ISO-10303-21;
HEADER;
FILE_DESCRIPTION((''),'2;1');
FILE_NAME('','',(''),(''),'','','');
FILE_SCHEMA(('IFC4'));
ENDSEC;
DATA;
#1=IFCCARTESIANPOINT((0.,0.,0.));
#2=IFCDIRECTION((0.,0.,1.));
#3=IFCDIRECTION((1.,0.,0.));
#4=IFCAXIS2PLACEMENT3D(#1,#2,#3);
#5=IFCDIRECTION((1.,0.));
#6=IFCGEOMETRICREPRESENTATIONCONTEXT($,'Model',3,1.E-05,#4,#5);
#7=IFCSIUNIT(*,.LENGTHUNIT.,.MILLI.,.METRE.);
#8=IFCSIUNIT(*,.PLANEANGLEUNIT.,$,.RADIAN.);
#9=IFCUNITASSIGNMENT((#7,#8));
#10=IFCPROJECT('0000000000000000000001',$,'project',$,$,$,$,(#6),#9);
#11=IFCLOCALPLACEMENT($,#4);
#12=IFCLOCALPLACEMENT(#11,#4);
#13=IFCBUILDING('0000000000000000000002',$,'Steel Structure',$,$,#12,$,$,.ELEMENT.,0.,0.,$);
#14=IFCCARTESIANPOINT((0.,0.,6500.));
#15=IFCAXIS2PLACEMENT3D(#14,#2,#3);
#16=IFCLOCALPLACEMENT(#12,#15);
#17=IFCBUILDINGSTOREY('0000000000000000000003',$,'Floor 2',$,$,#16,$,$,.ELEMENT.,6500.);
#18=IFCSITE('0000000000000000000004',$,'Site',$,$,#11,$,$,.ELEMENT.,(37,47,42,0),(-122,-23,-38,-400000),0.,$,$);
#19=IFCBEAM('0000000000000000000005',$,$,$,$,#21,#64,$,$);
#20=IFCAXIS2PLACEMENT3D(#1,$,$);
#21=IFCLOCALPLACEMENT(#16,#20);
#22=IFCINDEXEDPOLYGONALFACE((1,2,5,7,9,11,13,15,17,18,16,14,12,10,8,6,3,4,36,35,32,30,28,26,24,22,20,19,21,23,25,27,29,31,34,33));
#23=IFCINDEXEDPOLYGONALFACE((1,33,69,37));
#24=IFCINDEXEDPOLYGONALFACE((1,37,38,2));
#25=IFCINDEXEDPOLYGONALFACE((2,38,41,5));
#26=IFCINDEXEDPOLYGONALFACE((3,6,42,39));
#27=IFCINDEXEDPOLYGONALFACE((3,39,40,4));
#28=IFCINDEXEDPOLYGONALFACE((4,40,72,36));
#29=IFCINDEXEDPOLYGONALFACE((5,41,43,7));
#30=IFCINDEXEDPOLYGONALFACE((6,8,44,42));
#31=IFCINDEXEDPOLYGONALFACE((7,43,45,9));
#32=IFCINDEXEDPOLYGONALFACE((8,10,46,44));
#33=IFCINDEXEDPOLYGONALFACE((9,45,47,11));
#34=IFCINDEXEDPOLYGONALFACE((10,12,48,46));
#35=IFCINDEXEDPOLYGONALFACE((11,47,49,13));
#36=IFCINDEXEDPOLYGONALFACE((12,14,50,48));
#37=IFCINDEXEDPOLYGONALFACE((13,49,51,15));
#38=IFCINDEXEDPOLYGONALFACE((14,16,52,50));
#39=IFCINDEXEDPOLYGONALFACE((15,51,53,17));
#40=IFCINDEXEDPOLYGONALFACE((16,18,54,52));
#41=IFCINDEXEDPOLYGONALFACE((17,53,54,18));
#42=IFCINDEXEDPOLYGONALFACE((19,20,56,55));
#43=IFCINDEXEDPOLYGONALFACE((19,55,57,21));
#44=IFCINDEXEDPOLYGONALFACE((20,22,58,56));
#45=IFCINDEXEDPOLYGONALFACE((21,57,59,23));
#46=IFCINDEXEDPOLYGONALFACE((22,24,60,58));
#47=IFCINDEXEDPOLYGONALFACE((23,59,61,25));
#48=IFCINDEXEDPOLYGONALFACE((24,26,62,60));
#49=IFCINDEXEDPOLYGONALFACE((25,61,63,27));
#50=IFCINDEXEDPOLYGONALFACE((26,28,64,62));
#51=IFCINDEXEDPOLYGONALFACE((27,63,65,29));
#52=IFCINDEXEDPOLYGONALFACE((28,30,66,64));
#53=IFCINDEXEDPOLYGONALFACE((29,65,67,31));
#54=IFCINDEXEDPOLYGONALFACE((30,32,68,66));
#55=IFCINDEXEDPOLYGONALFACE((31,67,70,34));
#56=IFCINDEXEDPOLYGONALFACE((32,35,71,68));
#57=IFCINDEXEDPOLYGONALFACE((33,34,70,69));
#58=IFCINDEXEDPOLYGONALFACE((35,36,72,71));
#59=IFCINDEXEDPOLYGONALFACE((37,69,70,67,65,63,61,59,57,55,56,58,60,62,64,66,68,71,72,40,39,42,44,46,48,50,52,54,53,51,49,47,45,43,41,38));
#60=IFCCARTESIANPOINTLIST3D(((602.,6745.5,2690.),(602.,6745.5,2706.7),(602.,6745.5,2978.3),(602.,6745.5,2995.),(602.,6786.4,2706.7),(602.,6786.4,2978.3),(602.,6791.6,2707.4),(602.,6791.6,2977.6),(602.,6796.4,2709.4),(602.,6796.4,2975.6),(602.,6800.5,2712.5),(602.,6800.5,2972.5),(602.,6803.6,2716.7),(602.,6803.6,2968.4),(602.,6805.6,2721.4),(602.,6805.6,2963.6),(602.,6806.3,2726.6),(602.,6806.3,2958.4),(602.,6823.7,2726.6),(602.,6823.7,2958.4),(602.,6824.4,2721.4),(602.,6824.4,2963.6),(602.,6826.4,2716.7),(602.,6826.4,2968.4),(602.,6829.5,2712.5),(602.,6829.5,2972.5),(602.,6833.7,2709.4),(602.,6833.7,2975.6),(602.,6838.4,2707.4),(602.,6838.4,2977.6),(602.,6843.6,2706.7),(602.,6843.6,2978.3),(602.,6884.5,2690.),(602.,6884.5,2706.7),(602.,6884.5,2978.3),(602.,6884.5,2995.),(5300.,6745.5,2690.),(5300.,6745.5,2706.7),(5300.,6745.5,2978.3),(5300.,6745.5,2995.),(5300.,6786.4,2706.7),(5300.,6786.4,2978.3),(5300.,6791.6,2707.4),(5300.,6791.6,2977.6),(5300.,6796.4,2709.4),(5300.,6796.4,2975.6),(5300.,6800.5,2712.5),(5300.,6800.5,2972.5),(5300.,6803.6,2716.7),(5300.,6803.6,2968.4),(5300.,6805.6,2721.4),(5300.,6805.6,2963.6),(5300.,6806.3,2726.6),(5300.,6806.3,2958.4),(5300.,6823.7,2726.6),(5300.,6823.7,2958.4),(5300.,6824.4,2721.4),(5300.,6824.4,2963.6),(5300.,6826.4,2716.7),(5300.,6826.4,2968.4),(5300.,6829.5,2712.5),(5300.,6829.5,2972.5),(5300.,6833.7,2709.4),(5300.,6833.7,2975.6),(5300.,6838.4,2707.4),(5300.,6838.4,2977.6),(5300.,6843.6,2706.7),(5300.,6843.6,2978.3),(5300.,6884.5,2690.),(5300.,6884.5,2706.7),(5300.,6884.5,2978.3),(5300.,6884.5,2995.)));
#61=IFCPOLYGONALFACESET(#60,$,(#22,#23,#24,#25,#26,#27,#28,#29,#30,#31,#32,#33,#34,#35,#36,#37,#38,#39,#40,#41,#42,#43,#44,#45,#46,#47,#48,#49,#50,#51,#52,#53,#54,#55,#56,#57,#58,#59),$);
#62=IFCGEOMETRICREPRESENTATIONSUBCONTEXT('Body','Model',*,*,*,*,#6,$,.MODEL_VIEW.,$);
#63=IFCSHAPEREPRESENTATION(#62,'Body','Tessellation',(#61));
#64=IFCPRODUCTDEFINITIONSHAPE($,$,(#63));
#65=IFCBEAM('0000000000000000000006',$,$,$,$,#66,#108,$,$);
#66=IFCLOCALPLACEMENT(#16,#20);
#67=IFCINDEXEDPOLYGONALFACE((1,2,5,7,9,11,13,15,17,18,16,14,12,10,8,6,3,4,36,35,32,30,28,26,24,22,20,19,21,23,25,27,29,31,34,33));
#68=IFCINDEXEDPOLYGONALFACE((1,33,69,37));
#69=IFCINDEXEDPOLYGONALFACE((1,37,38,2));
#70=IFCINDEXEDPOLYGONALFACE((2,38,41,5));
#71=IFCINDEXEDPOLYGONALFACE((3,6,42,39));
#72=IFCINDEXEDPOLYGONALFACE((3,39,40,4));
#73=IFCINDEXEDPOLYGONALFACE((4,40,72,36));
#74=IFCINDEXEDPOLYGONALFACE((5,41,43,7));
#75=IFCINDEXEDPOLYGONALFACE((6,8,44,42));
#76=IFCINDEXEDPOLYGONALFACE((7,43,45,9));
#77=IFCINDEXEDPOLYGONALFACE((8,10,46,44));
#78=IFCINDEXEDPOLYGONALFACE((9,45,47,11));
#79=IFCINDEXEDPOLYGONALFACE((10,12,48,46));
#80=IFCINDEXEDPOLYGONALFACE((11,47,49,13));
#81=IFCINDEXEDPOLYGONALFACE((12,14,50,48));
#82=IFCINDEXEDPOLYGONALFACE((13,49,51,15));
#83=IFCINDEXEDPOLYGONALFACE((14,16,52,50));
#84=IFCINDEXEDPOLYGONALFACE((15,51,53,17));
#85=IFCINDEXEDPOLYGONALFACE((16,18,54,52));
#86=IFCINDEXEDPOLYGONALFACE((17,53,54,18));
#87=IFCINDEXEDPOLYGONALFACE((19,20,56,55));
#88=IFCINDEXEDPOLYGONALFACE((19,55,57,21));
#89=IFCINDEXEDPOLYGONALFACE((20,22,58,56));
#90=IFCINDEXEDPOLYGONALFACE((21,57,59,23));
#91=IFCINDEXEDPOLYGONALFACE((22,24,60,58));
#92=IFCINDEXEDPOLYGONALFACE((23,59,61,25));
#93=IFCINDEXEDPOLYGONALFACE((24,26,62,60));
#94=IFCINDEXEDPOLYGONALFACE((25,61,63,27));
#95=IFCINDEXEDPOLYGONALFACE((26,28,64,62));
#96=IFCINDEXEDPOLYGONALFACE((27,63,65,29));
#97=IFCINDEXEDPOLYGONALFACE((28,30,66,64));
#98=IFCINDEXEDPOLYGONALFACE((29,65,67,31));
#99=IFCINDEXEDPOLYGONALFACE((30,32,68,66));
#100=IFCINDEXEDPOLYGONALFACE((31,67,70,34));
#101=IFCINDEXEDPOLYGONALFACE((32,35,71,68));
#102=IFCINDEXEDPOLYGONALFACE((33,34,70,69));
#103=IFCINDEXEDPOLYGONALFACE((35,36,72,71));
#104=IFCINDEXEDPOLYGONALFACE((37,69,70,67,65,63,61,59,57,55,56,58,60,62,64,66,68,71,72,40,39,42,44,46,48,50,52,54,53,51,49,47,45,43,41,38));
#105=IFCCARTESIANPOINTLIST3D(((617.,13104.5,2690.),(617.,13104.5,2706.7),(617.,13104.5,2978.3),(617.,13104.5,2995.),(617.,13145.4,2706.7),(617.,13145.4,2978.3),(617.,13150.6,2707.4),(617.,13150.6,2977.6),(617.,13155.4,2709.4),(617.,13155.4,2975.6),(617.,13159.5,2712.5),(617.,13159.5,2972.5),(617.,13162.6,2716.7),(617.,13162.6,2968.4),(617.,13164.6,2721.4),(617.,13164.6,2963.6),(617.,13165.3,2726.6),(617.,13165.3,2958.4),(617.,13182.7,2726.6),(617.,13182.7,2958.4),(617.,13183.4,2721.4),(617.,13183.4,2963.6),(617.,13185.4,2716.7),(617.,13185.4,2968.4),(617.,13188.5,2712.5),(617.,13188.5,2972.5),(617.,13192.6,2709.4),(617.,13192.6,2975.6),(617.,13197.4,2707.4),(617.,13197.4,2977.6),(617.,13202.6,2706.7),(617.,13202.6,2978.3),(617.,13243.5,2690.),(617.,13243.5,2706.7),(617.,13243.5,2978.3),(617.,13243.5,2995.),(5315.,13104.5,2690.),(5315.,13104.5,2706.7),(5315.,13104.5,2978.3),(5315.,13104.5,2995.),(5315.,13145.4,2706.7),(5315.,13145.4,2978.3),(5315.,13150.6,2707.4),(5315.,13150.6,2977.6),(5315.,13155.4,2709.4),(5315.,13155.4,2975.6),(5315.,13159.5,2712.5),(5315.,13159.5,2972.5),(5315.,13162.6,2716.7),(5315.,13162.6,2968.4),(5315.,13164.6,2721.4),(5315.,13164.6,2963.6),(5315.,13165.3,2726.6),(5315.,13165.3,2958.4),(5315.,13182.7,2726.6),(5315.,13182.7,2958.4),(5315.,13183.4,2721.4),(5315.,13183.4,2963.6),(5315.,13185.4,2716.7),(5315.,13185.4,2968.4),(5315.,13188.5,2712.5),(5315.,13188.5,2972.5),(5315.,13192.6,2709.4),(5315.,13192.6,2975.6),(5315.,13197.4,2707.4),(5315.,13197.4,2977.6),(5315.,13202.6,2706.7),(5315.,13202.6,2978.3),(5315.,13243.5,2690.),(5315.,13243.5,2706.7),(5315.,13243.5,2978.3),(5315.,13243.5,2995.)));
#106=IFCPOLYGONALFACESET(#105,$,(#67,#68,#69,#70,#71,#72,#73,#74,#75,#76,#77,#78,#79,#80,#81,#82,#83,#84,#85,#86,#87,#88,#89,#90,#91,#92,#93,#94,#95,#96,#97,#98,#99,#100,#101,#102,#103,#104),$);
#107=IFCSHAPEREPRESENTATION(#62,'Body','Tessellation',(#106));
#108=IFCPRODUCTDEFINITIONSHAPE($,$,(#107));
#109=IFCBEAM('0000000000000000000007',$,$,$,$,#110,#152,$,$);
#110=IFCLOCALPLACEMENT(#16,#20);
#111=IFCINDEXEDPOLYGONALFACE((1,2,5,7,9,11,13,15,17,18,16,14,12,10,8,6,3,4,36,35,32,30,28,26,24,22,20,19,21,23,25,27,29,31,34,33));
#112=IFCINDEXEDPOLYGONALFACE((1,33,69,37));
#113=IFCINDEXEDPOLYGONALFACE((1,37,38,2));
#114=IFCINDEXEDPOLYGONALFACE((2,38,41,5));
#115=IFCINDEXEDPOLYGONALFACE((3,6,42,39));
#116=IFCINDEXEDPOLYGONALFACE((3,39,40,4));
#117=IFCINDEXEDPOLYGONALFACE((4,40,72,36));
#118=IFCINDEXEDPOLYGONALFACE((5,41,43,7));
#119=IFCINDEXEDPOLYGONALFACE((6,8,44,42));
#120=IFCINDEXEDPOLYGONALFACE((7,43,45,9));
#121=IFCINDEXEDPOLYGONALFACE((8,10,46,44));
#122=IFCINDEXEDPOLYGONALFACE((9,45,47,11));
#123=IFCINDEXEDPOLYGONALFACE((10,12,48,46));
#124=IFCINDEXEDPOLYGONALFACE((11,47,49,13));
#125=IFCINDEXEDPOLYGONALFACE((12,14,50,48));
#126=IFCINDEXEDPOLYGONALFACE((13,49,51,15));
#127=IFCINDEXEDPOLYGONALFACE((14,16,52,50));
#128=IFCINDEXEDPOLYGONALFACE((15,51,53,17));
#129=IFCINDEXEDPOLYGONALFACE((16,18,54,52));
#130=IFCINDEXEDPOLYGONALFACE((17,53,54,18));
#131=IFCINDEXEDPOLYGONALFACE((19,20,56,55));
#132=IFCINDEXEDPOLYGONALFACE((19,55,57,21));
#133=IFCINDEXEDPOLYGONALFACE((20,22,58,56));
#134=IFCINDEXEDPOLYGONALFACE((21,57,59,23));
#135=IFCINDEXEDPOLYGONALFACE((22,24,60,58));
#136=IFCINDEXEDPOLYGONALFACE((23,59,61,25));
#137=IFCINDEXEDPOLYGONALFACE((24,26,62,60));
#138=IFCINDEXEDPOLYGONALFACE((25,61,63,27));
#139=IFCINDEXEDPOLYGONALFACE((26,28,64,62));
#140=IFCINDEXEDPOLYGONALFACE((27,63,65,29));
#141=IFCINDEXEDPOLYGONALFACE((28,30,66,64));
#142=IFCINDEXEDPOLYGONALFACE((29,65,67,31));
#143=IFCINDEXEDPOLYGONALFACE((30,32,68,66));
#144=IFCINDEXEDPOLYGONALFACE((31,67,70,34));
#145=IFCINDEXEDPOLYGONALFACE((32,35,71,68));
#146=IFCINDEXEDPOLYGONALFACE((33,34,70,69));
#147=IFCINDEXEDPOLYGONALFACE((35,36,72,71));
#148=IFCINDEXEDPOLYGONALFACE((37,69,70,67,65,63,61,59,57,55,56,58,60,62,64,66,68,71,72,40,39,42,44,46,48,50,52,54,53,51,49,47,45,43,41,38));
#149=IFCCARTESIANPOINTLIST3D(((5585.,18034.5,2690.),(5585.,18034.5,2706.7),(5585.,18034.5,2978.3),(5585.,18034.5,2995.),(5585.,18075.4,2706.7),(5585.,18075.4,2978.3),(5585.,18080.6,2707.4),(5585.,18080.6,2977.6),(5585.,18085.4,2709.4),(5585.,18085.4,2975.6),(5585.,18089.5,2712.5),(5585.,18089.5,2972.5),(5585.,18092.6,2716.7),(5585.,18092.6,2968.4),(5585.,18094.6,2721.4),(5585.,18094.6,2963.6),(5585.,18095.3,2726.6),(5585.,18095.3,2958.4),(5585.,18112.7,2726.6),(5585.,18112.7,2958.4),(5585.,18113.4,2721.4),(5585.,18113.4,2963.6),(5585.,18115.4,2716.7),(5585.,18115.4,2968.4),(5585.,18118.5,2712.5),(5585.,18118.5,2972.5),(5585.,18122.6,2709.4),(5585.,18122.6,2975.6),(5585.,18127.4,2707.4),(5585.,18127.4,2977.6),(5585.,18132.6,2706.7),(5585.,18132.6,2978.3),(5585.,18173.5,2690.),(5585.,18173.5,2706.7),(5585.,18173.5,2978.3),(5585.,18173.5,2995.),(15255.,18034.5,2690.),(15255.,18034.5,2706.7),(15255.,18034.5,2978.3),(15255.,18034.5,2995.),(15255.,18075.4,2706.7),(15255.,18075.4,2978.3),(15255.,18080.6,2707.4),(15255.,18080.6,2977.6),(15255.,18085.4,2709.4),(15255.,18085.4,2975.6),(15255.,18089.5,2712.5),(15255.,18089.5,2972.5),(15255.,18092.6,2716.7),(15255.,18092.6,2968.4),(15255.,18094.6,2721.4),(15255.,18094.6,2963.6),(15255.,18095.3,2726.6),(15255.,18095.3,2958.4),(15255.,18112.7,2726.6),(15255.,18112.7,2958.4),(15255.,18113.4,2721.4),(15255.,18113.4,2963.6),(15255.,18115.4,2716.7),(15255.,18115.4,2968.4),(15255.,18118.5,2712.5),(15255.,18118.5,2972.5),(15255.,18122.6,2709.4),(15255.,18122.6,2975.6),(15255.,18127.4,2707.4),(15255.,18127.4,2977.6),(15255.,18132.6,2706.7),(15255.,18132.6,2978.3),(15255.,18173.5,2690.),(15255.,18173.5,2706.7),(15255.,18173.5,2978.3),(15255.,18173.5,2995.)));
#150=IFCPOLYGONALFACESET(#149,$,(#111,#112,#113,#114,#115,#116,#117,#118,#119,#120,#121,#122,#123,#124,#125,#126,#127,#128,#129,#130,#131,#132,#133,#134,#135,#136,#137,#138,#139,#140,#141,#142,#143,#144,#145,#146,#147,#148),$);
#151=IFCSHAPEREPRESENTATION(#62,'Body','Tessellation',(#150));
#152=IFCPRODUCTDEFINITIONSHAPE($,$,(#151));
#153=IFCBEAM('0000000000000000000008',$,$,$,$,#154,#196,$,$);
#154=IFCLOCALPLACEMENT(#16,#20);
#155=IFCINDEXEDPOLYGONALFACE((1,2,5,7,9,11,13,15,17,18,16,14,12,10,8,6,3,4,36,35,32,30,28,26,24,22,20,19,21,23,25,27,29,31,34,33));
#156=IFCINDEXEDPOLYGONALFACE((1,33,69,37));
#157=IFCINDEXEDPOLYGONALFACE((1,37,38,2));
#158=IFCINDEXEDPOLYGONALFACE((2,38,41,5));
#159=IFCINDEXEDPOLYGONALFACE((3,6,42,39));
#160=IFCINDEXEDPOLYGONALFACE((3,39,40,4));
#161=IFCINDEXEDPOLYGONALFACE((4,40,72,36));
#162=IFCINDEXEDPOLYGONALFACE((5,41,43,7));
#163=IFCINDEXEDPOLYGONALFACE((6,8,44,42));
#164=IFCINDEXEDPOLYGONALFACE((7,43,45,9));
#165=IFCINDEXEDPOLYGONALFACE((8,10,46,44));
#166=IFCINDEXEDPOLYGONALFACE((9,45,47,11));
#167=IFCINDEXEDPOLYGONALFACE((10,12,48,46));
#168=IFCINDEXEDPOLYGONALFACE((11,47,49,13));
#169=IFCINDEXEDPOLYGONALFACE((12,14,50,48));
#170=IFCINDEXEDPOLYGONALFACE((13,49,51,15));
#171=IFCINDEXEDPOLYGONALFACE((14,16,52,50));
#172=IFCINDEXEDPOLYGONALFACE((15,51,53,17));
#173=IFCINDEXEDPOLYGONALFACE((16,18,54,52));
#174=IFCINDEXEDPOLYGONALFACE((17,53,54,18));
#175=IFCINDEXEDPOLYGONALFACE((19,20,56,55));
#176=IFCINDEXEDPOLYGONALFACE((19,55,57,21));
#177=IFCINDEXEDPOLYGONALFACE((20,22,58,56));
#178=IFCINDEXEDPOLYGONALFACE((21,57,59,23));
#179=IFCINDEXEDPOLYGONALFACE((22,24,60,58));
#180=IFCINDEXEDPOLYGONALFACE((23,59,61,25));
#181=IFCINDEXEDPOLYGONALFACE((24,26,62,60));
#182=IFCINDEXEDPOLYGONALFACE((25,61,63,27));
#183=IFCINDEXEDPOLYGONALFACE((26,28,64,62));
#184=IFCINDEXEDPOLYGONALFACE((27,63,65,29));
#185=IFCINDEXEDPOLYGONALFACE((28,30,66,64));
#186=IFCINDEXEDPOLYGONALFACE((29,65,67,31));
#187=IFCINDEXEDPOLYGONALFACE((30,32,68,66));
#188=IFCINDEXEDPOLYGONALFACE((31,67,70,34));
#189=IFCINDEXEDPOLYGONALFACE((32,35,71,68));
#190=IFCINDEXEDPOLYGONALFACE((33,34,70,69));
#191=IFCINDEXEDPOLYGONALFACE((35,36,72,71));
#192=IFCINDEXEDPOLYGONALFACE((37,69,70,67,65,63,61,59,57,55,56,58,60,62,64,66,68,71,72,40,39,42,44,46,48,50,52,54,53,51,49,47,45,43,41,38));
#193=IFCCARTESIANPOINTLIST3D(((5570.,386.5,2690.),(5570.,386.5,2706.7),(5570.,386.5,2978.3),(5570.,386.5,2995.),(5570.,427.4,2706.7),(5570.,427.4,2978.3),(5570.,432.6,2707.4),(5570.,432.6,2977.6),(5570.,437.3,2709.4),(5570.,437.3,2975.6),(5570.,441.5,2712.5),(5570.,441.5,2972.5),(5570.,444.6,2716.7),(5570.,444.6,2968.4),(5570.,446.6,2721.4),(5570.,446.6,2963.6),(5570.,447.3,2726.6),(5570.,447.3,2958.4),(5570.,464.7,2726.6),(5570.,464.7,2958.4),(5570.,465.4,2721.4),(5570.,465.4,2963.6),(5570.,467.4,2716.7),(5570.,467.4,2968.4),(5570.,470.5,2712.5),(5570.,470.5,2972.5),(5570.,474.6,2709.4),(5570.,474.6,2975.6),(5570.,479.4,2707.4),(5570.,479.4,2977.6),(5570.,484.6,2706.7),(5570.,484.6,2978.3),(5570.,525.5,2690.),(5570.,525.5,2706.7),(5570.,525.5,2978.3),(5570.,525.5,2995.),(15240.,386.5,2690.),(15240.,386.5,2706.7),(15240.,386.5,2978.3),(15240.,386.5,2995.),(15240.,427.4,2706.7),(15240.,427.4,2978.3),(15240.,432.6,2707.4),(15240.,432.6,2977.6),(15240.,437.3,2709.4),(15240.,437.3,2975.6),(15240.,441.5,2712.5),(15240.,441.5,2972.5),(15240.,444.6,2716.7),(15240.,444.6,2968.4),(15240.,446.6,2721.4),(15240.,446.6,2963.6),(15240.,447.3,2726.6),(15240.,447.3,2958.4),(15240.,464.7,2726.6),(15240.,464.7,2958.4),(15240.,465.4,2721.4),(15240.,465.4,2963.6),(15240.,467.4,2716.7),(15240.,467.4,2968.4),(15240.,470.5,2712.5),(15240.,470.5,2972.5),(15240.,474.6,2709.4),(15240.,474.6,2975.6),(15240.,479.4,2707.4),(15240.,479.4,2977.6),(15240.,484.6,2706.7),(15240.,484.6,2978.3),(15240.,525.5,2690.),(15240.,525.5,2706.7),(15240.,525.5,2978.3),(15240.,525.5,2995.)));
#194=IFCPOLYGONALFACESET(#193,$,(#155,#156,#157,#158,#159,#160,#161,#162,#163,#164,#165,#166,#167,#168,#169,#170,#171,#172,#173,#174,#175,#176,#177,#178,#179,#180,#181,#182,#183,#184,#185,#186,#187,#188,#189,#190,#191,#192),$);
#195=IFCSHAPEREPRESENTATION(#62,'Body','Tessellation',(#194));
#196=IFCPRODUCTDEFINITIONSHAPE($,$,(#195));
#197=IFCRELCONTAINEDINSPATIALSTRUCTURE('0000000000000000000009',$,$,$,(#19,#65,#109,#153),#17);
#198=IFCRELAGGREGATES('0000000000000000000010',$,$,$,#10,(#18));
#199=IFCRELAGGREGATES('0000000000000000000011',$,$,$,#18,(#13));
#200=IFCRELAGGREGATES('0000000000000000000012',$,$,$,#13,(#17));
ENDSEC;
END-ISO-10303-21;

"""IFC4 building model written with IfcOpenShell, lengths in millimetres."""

from ifc_helpers import new_model, si_unit, direction, frame, origin_with_axes, origin_2d_with_axis, place, context, subcontext, project, spatial, i_section, extrude, element, save


model = new_model("IFC4")

# Units and contexts
model_context = context("Model", 3, precision=1e-05, world=origin_with_axes(), true_north=direction((1.0, 0.0)))
body_context = subcontext(model_context, "Body", "Model", "MODEL_VIEW")
ifc_project = project(units=[si_unit("LENGTHUNIT", "METRE", prefix="MILLI"), si_unit("PLANEANGLEUNIT", "RADIAN")], contexts=[model_context])

# Site, building, storey
site_placement = place(None, origin_with_axes())
site = spatial("IfcSite", under=ifc_project, at=site_placement, Name="Site", CompositionType="ELEMENT", RefLatitude=(37, 47, 42, 0), RefLongitude=(-122, -23, -38, -400000), RefElevation=0.0)
building_placement = place(site_placement, origin_with_axes())
building = spatial("IfcBuilding", under=site, at=building_placement, Name="Steel Structure", CompositionType="ELEMENT", ElevationOfRefHeight=0.0, ElevationOfTerrain=0.0)
storey_placement = place(building_placement, frame((0.0, 0.0, 6500.0), z_axis=(0.0, 0.0, 1.0), x_axis=(1.0, 0.0, 0.0)))
storey = spatial("IfcBuildingStorey", under=building, at=storey_placement, Name="Floor 2", CompositionType="ELEMENT", Elevation=6500.0)

# Beams
beam_1_placement = place(storey_placement, frame((5300.0, 6815.0, 2690.0), z_axis=(-1.0, 0.0, 0.0), x_axis=(0.0, -1.0, 0.0)))
element("IfcBeam", 1, at=beam_1_placement, inside=storey, context=body_context, shape_type="SweptSolid", body=[
    extrude(i_section(OverallWidth=139.0, OverallDepth=305.0, WebThickness=17.4, FlangeThickness=16.7, FilletRadius=19.9, at=origin_2d_with_axis()), frame((0.0, 152.5, 0.0), z_axis=(0.0, 0.0, 1.0), x_axis=(1.0, 0.0, 0.0)), (0.0, 0.0, 1.0), 4698.0),
])
beam_2_placement = place(storey_placement, frame((617.0, 13174.0, 2690.0), z_axis=(1.0, 0.0, 0.0), x_axis=(0.0, 1.0, 0.0)))
element("IfcBeam", 2, at=beam_2_placement, inside=storey, context=body_context, shape_type="SweptSolid", body=[
    extrude(i_section(OverallWidth=139.0, OverallDepth=305.0, WebThickness=17.4, FlangeThickness=16.7, FilletRadius=19.9, at=origin_2d_with_axis()), frame((0.0, 152.5, 0.0), z_axis=(0.0, 0.0, 1.0), x_axis=(1.0, 0.0, 0.0)), (0.0, 0.0, 1.0), 4698.0),
])
for number, where, z_axis, x_axis in (
    (3, (15255.0, 18104.0, 2690.0), (-1.0, 0.0, 0.0), (0.0, -1.0, 0.0)),
    (4, (15240.0, 456.0, 2690.0), (-1.0, 0.0, 0.0), (0.0, -1.0, 0.0)),
):
    element("IfcBeam", number, at=place(storey_placement, frame(where, z_axis=z_axis, x_axis=x_axis)), inside=storey, context=body_context, shape_type="SweptSolid", body=[
        extrude(i_section(OverallWidth=139.0, OverallDepth=305.0, WebThickness=17.4, FlangeThickness=16.7, FilletRadius=19.9, at=origin_2d_with_axis()), frame((0.0, 152.5, 0.0), z_axis=(0.0, 0.0, 1.0), x_axis=(1.0, 0.0, 0.0)), (0.0, 0.0, 1.0), 9670.0),
    ])

save(model, "model.ifc")
